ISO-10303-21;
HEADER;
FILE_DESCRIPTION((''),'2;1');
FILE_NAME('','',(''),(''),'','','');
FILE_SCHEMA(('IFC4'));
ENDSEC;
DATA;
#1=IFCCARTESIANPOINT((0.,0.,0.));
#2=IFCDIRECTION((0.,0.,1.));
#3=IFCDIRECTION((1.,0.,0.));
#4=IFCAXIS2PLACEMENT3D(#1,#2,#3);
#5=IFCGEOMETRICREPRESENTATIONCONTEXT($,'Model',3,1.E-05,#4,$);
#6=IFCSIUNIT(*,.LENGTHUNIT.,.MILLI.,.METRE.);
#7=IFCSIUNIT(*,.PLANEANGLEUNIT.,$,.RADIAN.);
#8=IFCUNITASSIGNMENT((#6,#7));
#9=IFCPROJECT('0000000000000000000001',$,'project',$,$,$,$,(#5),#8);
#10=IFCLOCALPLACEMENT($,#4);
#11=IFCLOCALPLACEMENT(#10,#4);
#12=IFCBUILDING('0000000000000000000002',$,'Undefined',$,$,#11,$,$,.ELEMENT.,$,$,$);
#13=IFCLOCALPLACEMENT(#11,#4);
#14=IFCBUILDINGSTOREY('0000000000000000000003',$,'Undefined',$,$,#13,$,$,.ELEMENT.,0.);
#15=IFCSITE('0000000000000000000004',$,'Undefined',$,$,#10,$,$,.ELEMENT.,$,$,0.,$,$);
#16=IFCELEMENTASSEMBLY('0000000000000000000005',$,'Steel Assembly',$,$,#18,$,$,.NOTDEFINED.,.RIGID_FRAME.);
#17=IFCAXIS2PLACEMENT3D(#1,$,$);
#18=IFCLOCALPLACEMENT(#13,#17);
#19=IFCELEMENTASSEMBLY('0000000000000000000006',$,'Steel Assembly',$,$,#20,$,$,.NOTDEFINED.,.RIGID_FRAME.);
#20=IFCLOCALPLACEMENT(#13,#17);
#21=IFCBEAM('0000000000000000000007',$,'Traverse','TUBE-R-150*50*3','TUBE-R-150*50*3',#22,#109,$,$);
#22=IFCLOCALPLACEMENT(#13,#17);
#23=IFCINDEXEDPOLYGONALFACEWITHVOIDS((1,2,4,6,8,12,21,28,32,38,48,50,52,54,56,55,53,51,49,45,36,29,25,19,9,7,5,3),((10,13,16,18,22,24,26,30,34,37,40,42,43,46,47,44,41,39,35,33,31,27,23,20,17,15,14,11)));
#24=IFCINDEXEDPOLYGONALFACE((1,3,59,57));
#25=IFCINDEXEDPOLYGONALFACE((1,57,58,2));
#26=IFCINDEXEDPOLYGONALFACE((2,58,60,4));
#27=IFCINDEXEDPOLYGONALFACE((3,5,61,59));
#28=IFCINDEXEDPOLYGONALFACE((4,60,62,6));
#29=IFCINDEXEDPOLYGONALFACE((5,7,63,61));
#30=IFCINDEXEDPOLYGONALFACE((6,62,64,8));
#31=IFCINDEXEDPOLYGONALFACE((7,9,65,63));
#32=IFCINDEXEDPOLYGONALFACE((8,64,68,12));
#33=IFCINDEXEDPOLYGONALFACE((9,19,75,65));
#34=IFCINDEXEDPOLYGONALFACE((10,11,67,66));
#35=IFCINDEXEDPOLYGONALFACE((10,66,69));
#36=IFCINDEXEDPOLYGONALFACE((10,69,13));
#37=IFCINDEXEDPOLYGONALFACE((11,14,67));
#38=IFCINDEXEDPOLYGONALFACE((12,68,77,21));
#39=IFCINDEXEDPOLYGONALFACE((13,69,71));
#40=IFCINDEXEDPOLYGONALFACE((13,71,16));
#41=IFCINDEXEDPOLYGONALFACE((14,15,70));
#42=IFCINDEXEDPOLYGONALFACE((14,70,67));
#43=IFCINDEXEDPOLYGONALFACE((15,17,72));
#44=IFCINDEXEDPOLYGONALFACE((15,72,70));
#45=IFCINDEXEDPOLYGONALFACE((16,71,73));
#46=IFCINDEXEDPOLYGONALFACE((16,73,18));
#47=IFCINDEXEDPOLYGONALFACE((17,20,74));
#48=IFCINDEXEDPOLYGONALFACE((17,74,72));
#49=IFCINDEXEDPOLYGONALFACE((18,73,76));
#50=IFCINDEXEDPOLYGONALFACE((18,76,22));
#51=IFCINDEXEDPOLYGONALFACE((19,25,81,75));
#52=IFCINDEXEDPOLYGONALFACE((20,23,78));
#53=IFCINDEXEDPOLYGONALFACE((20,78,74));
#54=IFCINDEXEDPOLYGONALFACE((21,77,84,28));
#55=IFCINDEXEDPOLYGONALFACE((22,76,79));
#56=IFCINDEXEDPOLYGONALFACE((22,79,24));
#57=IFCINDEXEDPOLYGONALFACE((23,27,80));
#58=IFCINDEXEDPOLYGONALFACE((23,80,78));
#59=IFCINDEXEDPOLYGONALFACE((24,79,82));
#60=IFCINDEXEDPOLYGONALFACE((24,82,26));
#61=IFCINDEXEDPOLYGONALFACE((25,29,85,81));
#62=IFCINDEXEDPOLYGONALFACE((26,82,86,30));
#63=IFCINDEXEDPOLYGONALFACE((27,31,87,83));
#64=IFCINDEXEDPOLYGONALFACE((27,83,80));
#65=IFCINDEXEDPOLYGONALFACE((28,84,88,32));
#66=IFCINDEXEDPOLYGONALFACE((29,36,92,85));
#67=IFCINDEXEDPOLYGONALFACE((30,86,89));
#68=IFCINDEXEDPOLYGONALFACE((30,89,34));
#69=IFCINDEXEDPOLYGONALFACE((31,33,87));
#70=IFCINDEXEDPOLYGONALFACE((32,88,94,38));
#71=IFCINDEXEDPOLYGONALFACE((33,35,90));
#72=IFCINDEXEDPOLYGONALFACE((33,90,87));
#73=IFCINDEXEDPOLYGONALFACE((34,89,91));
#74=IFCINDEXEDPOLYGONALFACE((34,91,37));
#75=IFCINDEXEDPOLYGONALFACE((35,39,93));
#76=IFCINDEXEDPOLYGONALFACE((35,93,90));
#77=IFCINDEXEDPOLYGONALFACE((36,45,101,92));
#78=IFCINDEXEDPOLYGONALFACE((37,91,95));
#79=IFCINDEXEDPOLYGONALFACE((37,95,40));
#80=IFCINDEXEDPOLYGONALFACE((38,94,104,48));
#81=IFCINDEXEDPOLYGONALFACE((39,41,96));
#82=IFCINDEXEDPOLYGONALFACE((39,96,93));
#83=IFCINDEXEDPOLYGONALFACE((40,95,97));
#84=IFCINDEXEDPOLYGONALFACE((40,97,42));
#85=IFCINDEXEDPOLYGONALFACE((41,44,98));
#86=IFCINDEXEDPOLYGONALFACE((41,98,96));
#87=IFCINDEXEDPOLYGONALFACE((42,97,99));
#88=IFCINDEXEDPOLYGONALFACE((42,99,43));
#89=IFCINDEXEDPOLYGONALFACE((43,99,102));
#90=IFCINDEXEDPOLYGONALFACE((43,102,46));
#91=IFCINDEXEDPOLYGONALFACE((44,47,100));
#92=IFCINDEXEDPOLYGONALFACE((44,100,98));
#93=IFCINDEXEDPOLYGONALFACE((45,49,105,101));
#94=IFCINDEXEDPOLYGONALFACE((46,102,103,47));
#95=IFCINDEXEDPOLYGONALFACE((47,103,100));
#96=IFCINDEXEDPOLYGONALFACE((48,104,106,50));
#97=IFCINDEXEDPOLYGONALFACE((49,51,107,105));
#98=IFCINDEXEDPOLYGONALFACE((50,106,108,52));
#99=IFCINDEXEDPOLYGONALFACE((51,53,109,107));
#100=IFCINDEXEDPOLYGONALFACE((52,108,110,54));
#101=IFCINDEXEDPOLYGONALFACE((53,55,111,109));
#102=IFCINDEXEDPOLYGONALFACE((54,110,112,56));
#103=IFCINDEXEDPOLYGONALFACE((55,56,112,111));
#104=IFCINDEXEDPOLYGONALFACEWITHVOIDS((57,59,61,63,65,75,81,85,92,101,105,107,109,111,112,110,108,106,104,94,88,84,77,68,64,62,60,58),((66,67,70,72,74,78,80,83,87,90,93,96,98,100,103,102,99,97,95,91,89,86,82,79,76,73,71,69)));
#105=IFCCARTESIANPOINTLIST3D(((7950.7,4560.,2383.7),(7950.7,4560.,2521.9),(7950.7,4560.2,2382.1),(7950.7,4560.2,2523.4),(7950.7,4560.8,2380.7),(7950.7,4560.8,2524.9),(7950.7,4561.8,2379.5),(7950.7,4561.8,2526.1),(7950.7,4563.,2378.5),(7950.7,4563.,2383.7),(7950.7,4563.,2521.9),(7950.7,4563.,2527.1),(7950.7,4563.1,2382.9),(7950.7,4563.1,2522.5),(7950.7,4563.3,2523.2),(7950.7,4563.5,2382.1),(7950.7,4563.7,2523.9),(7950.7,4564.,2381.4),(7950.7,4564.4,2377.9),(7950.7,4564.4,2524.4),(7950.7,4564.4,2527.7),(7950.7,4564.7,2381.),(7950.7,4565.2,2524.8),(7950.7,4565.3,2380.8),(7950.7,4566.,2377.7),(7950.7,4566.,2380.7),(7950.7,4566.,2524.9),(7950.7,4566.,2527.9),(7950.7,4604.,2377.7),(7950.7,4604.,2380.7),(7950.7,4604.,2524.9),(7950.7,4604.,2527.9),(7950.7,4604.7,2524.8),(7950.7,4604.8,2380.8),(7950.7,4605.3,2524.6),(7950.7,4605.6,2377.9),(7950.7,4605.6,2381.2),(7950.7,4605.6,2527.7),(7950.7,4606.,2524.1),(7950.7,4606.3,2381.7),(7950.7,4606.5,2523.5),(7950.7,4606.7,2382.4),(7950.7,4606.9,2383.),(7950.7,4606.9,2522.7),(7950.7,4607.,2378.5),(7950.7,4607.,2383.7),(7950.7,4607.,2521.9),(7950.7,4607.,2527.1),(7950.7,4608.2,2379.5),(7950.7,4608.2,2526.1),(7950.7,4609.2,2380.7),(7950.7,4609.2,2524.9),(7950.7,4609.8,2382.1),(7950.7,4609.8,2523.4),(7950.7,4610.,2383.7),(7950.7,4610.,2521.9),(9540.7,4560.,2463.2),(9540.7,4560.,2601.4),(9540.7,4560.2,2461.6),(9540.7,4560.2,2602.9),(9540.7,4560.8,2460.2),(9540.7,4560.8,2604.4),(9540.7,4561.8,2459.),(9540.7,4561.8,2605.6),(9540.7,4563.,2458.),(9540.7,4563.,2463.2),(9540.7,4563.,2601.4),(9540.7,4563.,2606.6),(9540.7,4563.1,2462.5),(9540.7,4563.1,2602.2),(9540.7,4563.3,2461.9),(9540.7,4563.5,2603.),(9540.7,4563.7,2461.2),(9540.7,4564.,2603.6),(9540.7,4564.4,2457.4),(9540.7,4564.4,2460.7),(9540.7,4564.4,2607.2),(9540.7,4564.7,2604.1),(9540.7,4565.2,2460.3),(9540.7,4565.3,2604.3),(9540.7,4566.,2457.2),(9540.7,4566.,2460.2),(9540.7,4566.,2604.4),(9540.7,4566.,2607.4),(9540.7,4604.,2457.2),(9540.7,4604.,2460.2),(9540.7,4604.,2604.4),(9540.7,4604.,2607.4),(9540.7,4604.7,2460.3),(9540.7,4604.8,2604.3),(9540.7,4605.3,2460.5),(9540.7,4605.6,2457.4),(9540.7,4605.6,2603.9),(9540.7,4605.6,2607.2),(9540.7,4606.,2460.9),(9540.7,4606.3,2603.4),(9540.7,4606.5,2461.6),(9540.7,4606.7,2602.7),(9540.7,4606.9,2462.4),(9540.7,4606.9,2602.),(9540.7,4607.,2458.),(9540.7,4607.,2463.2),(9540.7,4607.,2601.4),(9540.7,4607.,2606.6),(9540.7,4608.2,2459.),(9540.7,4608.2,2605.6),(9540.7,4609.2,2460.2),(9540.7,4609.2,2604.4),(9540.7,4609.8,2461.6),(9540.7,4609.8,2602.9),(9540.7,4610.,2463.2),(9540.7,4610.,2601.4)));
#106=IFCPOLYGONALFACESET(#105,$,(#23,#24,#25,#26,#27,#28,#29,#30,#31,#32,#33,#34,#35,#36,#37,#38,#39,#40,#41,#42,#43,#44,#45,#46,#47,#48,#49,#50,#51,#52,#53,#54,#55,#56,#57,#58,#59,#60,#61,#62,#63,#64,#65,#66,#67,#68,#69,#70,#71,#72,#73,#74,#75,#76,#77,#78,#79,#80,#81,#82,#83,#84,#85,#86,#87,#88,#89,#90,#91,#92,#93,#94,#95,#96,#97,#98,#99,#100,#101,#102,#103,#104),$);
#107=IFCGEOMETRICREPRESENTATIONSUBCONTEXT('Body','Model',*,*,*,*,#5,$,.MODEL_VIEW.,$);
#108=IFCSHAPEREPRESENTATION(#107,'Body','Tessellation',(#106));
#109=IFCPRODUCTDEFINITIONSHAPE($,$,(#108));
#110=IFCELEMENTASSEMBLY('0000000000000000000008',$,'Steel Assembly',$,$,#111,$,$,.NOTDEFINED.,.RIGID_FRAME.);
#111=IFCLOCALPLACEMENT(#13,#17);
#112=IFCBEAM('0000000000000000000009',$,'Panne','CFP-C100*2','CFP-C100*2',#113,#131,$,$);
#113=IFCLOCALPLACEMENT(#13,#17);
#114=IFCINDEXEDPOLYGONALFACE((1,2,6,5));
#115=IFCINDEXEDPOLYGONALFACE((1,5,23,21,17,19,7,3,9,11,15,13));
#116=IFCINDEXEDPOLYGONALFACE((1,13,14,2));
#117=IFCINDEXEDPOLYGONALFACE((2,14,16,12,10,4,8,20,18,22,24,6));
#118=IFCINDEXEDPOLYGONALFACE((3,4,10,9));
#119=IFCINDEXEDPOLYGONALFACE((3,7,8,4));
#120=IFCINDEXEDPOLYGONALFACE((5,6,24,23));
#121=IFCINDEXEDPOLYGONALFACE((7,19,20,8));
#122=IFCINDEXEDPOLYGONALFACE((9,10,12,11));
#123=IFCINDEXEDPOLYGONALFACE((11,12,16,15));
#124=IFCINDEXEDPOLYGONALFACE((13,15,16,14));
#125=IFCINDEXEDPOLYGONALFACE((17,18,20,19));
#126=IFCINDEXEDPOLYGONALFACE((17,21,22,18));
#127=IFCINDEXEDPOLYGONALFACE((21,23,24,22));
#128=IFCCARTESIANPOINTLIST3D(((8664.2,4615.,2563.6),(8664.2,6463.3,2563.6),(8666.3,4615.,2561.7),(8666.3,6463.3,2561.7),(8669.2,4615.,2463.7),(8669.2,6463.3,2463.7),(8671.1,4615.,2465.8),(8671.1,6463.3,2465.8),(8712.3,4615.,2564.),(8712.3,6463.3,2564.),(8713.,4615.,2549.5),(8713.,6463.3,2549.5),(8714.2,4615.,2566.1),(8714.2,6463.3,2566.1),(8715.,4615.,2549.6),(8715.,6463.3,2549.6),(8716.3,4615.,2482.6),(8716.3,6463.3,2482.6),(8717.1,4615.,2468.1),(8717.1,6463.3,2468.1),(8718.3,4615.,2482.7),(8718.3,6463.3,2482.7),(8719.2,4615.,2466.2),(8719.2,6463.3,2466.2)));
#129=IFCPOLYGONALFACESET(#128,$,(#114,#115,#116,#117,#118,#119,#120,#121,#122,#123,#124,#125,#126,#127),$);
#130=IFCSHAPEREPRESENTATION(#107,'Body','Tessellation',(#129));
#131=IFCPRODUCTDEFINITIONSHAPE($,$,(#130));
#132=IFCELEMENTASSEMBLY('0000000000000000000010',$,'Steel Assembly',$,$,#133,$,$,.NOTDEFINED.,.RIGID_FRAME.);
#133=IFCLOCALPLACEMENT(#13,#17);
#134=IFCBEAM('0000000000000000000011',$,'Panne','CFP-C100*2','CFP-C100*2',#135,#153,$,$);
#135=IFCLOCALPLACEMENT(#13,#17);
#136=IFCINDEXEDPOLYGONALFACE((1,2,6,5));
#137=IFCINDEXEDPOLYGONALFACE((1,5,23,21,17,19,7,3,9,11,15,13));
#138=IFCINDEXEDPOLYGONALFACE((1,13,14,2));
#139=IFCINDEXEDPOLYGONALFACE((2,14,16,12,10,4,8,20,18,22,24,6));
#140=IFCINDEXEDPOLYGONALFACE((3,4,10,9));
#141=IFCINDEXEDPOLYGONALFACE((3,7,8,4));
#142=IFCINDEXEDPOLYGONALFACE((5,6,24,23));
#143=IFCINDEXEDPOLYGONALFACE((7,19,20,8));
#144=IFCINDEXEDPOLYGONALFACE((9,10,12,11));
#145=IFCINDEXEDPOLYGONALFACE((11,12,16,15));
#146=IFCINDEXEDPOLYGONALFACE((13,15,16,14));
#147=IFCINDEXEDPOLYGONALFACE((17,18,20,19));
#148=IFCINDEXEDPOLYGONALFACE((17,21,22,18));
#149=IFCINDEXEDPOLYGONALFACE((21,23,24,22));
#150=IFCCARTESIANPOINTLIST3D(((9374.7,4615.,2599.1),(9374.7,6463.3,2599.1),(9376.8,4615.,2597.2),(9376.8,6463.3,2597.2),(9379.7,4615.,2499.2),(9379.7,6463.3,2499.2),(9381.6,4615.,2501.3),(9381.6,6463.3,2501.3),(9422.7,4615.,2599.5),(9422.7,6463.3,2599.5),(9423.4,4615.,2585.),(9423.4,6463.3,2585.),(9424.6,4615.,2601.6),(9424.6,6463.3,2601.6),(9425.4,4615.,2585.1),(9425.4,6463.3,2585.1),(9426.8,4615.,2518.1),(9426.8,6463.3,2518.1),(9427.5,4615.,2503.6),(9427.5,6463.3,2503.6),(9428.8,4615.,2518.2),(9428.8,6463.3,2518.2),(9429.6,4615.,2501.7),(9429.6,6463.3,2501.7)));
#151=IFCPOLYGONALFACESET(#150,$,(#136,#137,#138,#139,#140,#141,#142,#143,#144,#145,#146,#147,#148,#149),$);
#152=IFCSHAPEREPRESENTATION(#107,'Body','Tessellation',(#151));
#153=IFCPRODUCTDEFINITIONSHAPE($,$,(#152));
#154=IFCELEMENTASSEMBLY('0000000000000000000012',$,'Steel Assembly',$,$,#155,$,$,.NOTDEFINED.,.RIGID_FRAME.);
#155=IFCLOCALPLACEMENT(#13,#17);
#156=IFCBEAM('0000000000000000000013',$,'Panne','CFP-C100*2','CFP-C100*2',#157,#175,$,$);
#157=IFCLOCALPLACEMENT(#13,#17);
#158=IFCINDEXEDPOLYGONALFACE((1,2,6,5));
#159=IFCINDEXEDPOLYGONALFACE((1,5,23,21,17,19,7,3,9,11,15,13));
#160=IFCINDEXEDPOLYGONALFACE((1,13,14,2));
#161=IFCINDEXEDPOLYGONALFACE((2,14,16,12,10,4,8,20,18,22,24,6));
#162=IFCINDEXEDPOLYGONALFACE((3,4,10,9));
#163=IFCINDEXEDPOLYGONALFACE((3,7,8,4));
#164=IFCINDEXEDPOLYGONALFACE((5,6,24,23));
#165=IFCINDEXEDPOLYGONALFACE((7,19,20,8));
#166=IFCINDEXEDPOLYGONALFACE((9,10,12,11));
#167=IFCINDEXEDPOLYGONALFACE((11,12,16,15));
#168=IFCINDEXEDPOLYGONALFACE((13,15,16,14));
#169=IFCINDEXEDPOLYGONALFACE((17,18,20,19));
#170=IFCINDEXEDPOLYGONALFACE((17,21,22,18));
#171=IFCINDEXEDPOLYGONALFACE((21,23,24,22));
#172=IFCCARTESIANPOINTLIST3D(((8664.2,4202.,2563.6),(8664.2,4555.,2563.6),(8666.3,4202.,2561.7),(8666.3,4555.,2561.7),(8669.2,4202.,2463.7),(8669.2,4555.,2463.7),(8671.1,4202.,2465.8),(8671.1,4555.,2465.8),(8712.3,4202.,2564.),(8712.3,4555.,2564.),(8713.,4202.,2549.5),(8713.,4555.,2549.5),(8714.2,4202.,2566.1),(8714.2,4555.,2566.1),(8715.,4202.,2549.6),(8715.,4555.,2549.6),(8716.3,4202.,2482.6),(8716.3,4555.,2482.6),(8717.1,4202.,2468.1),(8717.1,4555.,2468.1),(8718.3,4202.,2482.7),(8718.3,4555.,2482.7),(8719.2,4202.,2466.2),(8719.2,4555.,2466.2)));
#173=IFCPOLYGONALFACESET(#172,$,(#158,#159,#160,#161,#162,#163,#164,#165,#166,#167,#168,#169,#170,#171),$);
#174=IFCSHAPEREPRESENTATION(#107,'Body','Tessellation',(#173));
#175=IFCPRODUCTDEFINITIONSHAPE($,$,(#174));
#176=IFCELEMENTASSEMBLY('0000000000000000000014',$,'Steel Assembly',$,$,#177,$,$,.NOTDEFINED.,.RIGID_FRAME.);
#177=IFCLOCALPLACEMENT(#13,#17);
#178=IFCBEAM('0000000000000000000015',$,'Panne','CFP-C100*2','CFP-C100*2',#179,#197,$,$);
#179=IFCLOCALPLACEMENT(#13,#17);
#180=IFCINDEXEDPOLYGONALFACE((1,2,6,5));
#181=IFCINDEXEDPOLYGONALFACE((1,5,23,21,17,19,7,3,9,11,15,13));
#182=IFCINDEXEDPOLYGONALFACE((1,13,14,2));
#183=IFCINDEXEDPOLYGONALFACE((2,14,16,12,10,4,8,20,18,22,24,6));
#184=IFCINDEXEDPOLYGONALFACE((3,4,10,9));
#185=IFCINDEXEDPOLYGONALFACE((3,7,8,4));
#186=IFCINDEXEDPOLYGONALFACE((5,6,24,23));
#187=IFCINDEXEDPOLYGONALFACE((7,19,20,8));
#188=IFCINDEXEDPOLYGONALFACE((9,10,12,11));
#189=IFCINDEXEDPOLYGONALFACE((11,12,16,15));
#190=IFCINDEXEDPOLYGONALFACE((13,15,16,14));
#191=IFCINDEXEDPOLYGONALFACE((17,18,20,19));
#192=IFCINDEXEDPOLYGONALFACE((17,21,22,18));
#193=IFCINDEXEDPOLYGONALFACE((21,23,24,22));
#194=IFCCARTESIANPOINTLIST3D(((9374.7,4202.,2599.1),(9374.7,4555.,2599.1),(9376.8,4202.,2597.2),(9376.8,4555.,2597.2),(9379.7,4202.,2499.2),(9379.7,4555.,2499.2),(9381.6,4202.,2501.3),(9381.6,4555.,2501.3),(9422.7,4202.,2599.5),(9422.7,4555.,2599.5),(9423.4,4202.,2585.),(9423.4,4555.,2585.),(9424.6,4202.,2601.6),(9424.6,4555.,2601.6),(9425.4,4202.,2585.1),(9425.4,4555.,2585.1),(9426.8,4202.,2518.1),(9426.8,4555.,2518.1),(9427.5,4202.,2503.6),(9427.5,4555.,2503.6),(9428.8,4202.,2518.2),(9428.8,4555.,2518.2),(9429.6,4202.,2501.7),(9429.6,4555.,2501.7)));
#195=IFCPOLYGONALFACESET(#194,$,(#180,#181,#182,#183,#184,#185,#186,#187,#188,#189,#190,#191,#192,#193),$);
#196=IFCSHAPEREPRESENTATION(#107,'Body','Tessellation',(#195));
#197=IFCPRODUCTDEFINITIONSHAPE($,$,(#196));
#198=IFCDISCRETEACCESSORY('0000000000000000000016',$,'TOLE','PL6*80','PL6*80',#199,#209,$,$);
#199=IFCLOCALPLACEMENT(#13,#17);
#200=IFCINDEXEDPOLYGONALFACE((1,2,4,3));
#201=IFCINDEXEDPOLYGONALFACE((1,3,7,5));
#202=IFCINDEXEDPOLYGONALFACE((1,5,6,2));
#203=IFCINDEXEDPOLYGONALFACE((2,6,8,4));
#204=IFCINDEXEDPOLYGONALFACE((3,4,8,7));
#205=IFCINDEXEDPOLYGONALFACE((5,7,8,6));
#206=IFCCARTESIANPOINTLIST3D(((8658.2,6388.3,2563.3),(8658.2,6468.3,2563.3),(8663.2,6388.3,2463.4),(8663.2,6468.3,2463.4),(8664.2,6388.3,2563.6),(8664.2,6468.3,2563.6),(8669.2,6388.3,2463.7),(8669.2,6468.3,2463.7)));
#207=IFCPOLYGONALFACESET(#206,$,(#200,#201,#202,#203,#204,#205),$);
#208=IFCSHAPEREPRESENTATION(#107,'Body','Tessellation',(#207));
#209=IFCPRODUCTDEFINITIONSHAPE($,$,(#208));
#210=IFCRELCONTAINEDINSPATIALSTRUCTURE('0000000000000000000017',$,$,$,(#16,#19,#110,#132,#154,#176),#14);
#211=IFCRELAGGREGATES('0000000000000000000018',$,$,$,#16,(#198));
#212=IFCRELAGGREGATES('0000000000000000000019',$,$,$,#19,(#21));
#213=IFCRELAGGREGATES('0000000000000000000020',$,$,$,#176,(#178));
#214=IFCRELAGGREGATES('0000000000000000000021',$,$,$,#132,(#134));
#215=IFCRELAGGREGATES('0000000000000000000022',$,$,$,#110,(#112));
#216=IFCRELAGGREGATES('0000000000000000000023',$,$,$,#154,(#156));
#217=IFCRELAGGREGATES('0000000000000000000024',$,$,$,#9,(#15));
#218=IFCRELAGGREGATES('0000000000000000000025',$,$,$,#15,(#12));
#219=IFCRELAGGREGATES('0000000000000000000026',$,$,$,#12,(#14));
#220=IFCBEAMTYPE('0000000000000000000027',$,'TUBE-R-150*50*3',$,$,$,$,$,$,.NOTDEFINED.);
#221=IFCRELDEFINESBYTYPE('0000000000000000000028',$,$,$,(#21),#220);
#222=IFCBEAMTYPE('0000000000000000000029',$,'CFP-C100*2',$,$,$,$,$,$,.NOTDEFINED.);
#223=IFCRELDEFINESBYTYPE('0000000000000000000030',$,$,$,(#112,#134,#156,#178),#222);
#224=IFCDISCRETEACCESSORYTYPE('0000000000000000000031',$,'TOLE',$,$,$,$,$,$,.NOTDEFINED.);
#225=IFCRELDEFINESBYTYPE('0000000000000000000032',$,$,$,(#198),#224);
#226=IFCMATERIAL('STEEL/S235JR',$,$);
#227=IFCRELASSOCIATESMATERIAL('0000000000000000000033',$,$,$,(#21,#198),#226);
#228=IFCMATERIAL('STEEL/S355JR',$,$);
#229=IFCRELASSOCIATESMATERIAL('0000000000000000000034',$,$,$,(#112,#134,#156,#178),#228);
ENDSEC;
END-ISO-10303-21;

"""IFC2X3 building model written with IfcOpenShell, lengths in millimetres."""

from ifc_helpers import new_model, si_unit, frame, origin_with_axes, origin_2d_with_axis, place, context, subcontext, project, spatial, rectangle, hollow_rectangle, c_section, extrude, clip, halfspace, material, type_object, element, aggregate, save


model = new_model("IFC2X3")

# Units and contexts
model_context = context("Model", 3, precision=1e-05, world=origin_with_axes())
body_context = subcontext(model_context, "Body", "Model", "MODEL_VIEW")
ifc_project = project(units=[si_unit("LENGTHUNIT", "METRE", prefix="MILLI"), si_unit("PLANEANGLEUNIT", "RADIAN")], contexts=[model_context])

# Site, building, storey
site_placement = place(None, origin_with_axes())
site = spatial("IfcSite", under=ifc_project, at=site_placement, Name="Undefined", CompositionType="ELEMENT", RefElevation=0.0)
building_placement = place(site_placement, origin_with_axes())
building = spatial("IfcBuilding", under=site, at=building_placement, Name="Undefined", CompositionType="ELEMENT")
storey_placement = place(building_placement, origin_with_axes())
storey = spatial("IfcBuildingStorey", under=building, at=storey_placement, Name="Undefined", CompositionType="ELEMENT", Elevation=0.0)

# Element assemblies, beams
ifc_material_1 = material(Name="STEEL/S355JR")
assembly_1_placement = place(storey_placement, origin_with_axes())
assembly_1 = element("IfcElementAssembly", 1, at=assembly_1_placement, inside=storey, Name="Steel Assembly", AssemblyPlace="NOTDEFINED", PredefinedType="RIGID_FRAME")
ifc_material_2 = material(Name="STEEL/S235JR")
beam_type_1 = type_object("IfcBeamType", Name="TUBE-R-150*50*3", PredefinedType="NOTDEFINED")
assembly_2_placement = place(storey_placement, origin_with_axes())
assembly_2 = element("IfcElementAssembly", 2, at=assembly_2_placement, inside=storey, Name="Steel Assembly", AssemblyPlace="NOTDEFINED", PredefinedType="RIGID_FRAME")
beam_1_placement = place(assembly_2_placement, frame((7952.4, 4585.0, 2452.9), z_axis=(-0.049938, 0.0, 0.998752), x_axis=(0.998752, 0.0, 0.049938)))
beam_1 = element("IfcBeam", 3, at=beam_1_placement, type_object=beam_type_1, material=ifc_material_2, Name="Traverse", Description="TUBE-R-150*50*3", ObjectType="TUBE-R-150*50*3", context=body_context, shape_type="Clipping", body=[
    clip(clip(extrude(hollow_rectangle(XDim=50.0, YDim=150.0, WallThickness=3.0, InnerFilletRadius=3.0, OuterFilletRadius=6.0, at=origin_2d_with_axis()), frame((1597.8, 0.0, 0.0), z_axis=(-1.0, 0.0, 0.0), x_axis=(0.0, -1.0, 0.0)), (0.0, 0.0, 1.0), 1607.1), halfspace(frame((1594.0, 0.0, 75.0), z_axis=(-0.998752, 0.0, 0.049938), x_axis=(0.0, -1.0, 0.0)), True)), halfspace(frame((-2.7, 0.0, -19.9), z_axis=(0.998752, 0.0, -0.049938), x_axis=(0.0, -1.0, 0.0)), True)),
])
assembly_3_placement = place(storey_placement, origin_with_axes())
assembly_3 = element("IfcElementAssembly", 4, at=assembly_3_placement, inside=storey, Name="Steel Assembly", AssemblyPlace="NOTDEFINED", PredefinedType="RIGID_FRAME")
beam_type_2 = type_object("IfcBeamType", Name="CFP-C100*2", PredefinedType="NOTDEFINED")
beam_2_placement = place(assembly_3_placement, frame((8691.7, 4587.8, 2514.9), z_axis=(-0.049938, 0.0, 0.998752), x_axis=(0.0, 1.0, 0.0)))
beam_2 = element("IfcBeam", 5, at=beam_2_placement, type_object=beam_type_2, material=ifc_material_1, Name="Panne", Description="CFP-C100*2", ObjectType="CFP-C100*2", context=body_context, shape_type="SweptSolid", body=[
    extrude(c_section(Depth=100.0, Width=50.0, WallThickness=2.0, Girth=16.5, at=origin_2d_with_axis()), frame((1875.6, 0.0, 0.0), z_axis=(-1.0, 0.0, 0.0), x_axis=(0.0, -1.0, 0.0)), (0.0, 0.0, 1.0), 1848.3),
])
assembly_4_placement = place(storey_placement, origin_with_axes())
assembly_4 = element("IfcElementAssembly", 6, at=assembly_4_placement, inside=storey, Name="Steel Assembly", AssemblyPlace="NOTDEFINED", PredefinedType="RIGID_FRAME")
beam_3_placement = place(assembly_4_placement, frame((9402.1, 4587.8, 2550.4), z_axis=(-0.049938, 0.0, 0.998752), x_axis=(0.0, 1.0, 0.0)))
beam_3 = element("IfcBeam", 7, at=beam_3_placement, type_object=beam_type_2, material=ifc_material_1, Name="Panne", Description="CFP-C100*2", ObjectType="CFP-C100*2", context=body_context, shape_type="SweptSolid", body=[
    extrude(c_section(Depth=100.0, Width=50.0, WallThickness=2.0, Girth=16.5, at=origin_2d_with_axis()), frame((1875.6, 0.0, 0.0), z_axis=(-1.0, 0.0, 0.0), x_axis=(0.0, -1.0, 0.0)), (0.0, 0.0, 1.0), 1848.3),
])
assembly_5_placement = place(storey_placement, origin_with_axes())
assembly_5 = element("IfcElementAssembly", 8, at=assembly_5_placement, inside=storey, Name="Steel Assembly", AssemblyPlace="NOTDEFINED", PredefinedType="RIGID_FRAME")
beam_4_placement = place(assembly_5_placement, frame((8691.7, 4202.0, 2514.9), z_axis=(-0.049938, 0.0, 0.998752), x_axis=(0.0, 1.0, 0.0)))
beam_4 = element("IfcBeam", 9, at=beam_4_placement, type_object=beam_type_2, material=ifc_material_1, Name="Panne", Description="CFP-C100*2", ObjectType="CFP-C100*2", context=body_context, shape_type="SweptSolid", body=[
    extrude(c_section(Depth=100.0, Width=50.0, WallThickness=2.0, Girth=16.5, at=origin_2d_with_axis()), frame((353.0, 0.0, 0.0), z_axis=(-1.0, 0.0, 0.0), x_axis=(0.0, -1.0, 0.0)), (0.0, 0.0, 1.0), 353.0),
])
assembly_6_placement = place(storey_placement, origin_with_axes())
assembly_6 = element("IfcElementAssembly", 10, at=assembly_6_placement, inside=storey, Name="Steel Assembly", AssemblyPlace="NOTDEFINED", PredefinedType="RIGID_FRAME")
beam_5_placement = place(assembly_6_placement, frame((9402.1, 4202.0, 2550.4), z_axis=(-0.049938, 0.0, 0.998752), x_axis=(0.0, 1.0, 0.0)))
beam_5 = element("IfcBeam", 11, at=beam_5_placement, type_object=beam_type_2, material=ifc_material_1, Name="Panne", Description="CFP-C100*2", ObjectType="CFP-C100*2", context=body_context, shape_type="SweptSolid", body=[
    extrude(c_section(Depth=100.0, Width=50.0, WallThickness=2.0, Girth=16.5, at=origin_2d_with_axis()), frame((353.0, 0.0, 0.0), z_axis=(-1.0, 0.0, 0.0), x_axis=(0.0, -1.0, 0.0)), (0.0, 0.0, 1.0), 353.0),
])

# Discrete accessory
discrete_accessory_type_1 = type_object("IfcDiscreteAccessoryType", Name="TOLE")
discrete_accessory_1_placement = place(assembly_1_placement, frame((8661.2, 6428.3, 2563.4), z_axis=(0.0, 1.0, 0.0), x_axis=(0.049938, 0.0, -0.998752)))
discrete_accessory_1 = element("IfcDiscreteAccessory", 12, at=discrete_accessory_1_placement, type_object=discrete_accessory_type_1, material=ifc_material_2, Name="TOLE", Description="PL6*80", ObjectType="PL6*80", context=body_context, shape_type="SweptSolid", body=[
    extrude(rectangle(XDim=6.0, YDim=80.0, at=origin_2d_with_axis()), frame((100.0, 0.0, 0.0), z_axis=(-1.0, 0.0, 0.0), x_axis=(0.0, -1.0, 0.0)), (0.0, 0.0, 1.0), 100.0),
])
aggregate(assembly_1, [discrete_accessory_1])

aggregate(assembly_2, [beam_1])
aggregate(assembly_6, [beam_5])
aggregate(assembly_4, [beam_3])
aggregate(assembly_3, [beam_2])
aggregate(assembly_5, [beam_4])

save(model, "model.ifc")
